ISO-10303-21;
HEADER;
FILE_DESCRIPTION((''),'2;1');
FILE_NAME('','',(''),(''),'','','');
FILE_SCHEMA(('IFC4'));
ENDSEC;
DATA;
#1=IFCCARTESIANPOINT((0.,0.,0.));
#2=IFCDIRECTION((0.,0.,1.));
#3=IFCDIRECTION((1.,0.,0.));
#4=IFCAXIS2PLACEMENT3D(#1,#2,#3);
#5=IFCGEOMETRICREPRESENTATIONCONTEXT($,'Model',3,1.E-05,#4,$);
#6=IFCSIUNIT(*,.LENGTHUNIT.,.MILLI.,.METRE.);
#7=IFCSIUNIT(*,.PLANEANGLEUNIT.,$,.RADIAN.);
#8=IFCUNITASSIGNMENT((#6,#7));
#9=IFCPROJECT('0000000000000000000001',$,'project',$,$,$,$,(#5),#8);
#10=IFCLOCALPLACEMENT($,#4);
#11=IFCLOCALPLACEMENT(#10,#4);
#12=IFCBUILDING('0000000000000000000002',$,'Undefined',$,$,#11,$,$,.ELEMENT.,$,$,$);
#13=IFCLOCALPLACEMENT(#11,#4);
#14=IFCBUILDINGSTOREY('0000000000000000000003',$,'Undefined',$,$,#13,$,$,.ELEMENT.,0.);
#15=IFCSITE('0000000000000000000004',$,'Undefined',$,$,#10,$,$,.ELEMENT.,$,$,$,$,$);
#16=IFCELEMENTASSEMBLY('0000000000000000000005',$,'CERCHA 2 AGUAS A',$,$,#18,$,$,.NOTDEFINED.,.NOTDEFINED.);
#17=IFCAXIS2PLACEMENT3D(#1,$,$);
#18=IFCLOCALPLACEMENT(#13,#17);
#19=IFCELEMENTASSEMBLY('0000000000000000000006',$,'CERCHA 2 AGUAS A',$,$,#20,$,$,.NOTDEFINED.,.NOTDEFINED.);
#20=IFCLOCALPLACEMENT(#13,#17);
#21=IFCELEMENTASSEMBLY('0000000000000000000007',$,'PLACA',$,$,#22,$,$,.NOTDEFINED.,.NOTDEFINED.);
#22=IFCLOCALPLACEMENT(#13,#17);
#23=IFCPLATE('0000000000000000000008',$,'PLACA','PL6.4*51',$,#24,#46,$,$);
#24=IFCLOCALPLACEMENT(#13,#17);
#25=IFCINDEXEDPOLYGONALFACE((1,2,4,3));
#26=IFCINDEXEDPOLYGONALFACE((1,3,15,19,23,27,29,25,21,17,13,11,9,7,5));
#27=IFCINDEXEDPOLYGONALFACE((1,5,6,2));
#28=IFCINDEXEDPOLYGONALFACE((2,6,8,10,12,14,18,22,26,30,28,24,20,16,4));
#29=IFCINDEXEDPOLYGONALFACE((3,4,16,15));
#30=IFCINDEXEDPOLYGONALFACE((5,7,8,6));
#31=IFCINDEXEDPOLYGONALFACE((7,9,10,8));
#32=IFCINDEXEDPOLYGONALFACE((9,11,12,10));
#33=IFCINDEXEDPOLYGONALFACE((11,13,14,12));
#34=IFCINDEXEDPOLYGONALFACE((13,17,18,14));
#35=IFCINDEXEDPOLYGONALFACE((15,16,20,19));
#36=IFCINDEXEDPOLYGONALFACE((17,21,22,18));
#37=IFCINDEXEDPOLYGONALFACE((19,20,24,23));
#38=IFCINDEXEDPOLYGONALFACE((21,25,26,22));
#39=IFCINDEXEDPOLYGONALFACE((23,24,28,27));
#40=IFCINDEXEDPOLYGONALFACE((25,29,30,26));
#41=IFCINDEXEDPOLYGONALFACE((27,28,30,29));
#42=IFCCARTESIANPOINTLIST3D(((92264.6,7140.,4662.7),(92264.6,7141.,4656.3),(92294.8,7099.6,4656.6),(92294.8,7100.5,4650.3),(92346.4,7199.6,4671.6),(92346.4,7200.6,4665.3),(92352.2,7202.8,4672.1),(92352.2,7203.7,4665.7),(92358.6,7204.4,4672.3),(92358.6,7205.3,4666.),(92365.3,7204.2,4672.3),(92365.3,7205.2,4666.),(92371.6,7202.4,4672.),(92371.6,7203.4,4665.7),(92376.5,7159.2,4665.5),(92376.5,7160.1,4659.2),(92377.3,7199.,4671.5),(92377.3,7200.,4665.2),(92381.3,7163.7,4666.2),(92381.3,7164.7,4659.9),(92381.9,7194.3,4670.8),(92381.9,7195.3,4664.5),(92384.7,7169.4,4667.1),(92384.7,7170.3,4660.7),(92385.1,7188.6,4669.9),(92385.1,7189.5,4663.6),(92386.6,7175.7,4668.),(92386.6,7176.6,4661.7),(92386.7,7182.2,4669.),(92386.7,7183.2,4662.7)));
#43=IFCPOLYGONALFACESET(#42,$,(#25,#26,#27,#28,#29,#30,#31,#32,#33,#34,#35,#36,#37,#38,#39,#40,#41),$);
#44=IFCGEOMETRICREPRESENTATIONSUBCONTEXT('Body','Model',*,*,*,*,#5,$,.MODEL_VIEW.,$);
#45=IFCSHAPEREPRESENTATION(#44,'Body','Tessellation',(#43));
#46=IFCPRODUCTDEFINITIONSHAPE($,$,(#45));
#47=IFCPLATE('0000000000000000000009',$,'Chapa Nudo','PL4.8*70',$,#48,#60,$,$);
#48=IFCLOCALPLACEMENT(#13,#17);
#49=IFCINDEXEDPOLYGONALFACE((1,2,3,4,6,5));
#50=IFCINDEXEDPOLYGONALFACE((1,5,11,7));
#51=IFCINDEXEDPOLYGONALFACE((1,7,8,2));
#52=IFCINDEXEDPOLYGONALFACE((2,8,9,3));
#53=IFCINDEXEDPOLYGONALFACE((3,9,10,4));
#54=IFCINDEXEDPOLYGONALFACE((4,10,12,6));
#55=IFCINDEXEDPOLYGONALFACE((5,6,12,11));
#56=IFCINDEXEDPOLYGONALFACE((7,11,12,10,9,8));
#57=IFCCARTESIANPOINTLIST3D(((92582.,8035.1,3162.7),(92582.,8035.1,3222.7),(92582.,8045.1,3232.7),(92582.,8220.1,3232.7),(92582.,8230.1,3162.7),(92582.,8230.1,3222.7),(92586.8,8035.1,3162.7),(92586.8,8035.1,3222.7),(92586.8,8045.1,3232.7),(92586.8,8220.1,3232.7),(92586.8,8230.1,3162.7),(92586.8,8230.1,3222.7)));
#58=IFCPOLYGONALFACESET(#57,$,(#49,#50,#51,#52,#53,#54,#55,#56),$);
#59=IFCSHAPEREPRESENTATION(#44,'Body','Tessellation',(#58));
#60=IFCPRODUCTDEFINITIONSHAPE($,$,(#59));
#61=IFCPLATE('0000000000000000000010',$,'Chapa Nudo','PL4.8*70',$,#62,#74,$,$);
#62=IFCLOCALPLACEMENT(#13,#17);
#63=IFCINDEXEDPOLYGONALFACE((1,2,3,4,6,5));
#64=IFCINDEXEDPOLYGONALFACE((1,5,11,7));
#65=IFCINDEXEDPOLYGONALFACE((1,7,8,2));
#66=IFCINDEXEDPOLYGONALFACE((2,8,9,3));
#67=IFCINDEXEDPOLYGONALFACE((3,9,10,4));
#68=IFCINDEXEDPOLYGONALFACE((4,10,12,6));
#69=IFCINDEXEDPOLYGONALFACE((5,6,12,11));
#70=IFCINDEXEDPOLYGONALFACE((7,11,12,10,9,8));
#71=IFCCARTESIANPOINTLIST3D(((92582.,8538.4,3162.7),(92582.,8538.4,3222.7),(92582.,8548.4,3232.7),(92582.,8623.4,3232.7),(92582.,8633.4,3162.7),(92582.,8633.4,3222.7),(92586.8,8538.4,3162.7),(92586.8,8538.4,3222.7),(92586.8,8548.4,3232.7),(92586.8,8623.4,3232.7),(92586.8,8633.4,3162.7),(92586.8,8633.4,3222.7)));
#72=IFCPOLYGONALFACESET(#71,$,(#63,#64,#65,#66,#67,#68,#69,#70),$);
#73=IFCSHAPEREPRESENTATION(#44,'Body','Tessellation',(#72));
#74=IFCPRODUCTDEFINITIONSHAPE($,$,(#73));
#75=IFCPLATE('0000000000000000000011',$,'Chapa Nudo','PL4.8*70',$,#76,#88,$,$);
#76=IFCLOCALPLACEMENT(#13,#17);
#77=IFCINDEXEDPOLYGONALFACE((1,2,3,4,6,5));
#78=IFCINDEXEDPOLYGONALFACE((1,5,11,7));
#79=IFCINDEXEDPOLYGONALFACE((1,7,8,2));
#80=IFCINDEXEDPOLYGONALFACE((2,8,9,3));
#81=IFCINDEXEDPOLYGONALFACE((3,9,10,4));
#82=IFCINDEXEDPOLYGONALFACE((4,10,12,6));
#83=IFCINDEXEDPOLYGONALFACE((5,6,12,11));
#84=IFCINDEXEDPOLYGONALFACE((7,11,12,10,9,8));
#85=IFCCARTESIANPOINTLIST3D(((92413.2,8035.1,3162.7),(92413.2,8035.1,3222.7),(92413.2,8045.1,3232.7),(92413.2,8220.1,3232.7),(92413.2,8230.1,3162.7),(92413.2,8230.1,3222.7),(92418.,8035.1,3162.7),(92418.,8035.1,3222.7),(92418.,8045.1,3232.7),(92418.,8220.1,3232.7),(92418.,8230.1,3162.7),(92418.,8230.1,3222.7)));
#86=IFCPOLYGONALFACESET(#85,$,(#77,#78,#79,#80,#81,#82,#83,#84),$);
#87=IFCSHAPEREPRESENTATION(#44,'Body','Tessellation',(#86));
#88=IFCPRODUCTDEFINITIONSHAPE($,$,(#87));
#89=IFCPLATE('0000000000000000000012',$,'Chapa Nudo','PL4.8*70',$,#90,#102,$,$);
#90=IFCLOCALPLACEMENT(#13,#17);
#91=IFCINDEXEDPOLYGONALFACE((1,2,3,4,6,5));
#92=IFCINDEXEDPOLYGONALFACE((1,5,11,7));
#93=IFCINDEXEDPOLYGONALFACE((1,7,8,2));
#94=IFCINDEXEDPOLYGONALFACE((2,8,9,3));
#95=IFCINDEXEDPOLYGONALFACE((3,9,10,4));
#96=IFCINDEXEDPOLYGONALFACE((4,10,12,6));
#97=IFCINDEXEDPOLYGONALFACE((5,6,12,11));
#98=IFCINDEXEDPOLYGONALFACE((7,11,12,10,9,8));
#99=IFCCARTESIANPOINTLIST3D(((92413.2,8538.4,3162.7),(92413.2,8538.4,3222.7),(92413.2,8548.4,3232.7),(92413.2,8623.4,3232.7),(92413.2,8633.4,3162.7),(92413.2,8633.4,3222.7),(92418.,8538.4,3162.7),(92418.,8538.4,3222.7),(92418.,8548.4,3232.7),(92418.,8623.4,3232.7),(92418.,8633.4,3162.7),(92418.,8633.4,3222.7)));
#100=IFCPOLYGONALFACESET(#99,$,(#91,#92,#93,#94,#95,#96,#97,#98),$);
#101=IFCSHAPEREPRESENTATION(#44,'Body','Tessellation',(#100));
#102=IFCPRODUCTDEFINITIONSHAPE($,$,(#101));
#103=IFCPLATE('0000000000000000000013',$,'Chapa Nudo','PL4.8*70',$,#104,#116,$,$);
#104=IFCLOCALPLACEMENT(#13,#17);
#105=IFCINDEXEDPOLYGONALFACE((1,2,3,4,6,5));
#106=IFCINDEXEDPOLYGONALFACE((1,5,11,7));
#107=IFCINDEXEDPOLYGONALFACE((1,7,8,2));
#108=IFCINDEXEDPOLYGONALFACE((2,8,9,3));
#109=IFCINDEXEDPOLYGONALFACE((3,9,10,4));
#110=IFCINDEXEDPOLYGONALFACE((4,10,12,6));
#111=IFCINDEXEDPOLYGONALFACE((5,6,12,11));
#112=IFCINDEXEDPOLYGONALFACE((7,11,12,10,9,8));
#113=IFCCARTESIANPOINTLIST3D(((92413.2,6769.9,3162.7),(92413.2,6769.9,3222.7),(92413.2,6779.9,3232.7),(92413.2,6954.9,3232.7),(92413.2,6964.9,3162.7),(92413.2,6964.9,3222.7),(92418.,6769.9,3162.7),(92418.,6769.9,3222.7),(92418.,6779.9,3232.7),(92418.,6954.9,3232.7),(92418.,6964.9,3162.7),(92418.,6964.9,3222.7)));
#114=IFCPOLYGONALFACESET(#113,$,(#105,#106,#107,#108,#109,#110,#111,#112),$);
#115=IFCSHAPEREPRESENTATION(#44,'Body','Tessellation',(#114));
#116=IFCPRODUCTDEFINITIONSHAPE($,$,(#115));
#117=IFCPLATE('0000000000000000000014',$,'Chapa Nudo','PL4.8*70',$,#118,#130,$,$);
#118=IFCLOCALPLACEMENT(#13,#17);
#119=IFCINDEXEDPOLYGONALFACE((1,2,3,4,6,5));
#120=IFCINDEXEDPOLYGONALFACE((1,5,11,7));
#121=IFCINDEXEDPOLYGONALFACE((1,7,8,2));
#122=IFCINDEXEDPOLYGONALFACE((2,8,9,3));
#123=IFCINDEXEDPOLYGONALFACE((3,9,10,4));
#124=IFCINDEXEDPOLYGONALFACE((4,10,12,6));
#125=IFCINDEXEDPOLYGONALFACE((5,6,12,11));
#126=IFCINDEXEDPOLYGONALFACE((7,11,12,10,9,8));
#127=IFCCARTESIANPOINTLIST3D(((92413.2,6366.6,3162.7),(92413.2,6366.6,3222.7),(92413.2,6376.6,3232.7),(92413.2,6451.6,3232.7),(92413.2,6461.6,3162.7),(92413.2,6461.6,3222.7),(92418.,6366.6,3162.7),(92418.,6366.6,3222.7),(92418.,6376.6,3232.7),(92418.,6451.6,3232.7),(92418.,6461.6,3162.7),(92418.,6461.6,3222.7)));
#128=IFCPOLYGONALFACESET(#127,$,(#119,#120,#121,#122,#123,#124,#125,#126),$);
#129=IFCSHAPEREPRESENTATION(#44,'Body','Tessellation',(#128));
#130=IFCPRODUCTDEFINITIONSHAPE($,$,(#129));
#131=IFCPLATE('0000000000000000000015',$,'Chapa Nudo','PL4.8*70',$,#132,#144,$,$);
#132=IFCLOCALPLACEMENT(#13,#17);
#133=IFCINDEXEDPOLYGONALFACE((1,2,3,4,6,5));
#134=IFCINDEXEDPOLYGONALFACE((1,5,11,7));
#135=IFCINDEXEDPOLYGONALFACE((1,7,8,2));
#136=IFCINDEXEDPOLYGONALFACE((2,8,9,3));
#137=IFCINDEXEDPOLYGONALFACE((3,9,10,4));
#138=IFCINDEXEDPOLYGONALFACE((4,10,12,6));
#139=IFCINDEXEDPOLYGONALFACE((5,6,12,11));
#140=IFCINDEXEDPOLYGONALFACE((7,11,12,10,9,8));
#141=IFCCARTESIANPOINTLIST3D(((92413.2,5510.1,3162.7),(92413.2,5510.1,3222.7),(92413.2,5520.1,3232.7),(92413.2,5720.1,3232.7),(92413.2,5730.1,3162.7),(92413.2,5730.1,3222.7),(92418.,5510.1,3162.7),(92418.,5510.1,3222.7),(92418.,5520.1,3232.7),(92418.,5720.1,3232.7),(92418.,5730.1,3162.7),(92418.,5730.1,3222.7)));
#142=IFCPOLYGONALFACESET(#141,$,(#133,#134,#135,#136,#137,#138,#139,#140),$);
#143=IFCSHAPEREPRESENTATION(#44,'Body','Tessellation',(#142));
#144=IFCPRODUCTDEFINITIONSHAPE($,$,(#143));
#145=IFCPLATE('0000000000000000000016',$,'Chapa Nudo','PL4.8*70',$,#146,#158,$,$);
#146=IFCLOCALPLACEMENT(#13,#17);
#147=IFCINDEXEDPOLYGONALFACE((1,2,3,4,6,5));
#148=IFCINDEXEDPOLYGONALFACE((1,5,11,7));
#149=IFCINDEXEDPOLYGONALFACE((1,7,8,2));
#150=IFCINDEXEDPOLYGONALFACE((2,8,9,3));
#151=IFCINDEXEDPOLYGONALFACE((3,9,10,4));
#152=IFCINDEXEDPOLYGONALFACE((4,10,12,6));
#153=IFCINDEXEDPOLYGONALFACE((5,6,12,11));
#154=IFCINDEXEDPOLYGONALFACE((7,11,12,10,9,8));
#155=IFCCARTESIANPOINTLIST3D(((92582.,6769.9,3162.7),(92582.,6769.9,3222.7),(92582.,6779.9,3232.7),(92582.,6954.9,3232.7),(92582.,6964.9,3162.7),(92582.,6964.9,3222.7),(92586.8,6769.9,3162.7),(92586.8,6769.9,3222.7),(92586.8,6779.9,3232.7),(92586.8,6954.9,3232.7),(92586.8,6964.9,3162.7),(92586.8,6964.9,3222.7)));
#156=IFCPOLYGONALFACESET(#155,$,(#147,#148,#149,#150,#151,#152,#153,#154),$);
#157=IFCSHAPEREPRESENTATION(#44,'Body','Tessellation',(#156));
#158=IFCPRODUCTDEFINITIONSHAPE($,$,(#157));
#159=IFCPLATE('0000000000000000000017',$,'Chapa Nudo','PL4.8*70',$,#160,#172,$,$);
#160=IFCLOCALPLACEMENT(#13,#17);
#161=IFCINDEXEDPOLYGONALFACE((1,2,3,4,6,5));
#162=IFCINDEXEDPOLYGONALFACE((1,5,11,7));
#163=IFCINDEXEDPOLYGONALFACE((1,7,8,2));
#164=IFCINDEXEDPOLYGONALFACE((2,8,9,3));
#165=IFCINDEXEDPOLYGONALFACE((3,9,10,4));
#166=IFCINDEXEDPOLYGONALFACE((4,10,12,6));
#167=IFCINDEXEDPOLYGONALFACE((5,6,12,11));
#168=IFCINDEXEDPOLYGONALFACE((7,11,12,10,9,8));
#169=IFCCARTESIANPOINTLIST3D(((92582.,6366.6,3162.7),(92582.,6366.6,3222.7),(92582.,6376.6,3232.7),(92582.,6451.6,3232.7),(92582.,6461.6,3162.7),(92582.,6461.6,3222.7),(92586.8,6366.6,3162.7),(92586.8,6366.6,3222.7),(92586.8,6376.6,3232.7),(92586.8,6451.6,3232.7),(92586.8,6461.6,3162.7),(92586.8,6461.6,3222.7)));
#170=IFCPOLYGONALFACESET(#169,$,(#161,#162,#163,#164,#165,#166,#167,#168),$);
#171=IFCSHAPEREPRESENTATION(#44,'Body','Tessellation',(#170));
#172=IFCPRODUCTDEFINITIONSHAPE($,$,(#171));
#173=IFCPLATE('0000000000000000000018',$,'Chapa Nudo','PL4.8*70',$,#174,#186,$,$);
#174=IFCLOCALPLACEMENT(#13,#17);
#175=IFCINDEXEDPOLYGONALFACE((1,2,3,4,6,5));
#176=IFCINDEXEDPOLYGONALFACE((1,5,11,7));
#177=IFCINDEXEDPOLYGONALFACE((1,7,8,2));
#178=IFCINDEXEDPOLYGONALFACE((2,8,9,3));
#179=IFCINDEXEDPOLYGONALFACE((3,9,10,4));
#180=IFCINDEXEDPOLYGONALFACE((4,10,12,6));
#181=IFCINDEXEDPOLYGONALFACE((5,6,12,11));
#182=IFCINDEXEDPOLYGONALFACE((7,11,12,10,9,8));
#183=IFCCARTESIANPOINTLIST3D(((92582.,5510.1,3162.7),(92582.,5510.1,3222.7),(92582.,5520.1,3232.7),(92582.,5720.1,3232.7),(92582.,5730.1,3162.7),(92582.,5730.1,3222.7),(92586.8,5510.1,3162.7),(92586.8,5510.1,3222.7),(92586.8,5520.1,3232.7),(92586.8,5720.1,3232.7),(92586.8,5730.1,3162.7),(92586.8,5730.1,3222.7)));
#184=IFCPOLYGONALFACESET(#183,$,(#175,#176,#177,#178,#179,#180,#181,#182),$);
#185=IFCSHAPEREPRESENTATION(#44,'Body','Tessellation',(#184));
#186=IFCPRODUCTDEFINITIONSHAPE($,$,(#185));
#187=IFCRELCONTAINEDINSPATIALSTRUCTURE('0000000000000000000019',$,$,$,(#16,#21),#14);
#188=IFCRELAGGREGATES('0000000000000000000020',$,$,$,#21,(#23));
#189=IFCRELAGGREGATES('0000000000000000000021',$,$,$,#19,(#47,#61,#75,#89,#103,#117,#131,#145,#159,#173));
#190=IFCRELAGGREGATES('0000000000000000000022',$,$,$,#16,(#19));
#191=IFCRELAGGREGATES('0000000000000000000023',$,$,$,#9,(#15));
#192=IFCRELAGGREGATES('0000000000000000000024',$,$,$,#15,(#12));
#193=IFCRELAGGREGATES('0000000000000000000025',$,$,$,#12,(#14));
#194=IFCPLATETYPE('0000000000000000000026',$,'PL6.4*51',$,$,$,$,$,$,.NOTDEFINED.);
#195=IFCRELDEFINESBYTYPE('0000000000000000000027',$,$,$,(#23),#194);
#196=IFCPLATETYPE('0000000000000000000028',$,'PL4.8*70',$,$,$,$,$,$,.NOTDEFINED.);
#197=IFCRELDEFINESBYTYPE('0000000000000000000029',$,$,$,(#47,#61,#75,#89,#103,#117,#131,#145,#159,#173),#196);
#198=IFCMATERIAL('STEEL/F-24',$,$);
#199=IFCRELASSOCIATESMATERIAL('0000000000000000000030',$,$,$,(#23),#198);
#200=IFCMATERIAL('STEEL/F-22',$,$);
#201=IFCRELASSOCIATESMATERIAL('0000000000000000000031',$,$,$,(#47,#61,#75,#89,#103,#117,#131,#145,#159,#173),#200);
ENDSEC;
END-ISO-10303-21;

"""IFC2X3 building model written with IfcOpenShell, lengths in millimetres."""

from ifc_helpers import new_model, si_unit, frame, frame_2d, origin_with_axes, place, context, subcontext, project, spatial, polyline, circle_curve, parameter, trimmed, segment, composite_curve, outline, extrude, material, type_object, element, aggregate, save


model = new_model("IFC2X3")

# Units and contexts
model_context = context("Model", 3, precision=1e-05, world=origin_with_axes())
body_context = subcontext(model_context, "Body", "Model", "MODEL_VIEW")
ifc_project = project(units=[si_unit("LENGTHUNIT", "METRE", prefix="MILLI"), si_unit("PLANEANGLEUNIT", "RADIAN")], contexts=[model_context])

# Site, building, storey
site_placement = place(None, origin_with_axes())
site = spatial("IfcSite", under=ifc_project, at=site_placement, Name="Undefined", CompositionType="ELEMENT")
building_placement = place(site_placement, origin_with_axes())
building = spatial("IfcBuilding", under=site, at=building_placement, Name="Undefined", CompositionType="ELEMENT")
storey_placement = place(building_placement, origin_with_axes())
storey = spatial("IfcBuildingStorey", under=building, at=storey_placement, Name="Undefined", CompositionType="ELEMENT", Elevation=0.0)

# Shared definitions
ifc_material_1 = material(Name="STEEL/F-22")

# Element assemblies
assembly_1_placement = place(storey_placement, origin_with_axes())
assembly_1 = element("IfcElementAssembly", 1, at=assembly_1_placement, inside=storey, Name="CERCHA 2 AGUAS A", AssemblyPlace="NOTDEFINED", PredefinedType="NOTDEFINED")
assembly_2_placement = place(assembly_1_placement, origin_with_axes())
assembly_2 = element("IfcElementAssembly", 2, at=assembly_2_placement, Name="CERCHA 2 AGUAS A", AssemblyPlace="NOTDEFINED", PredefinedType="NOTDEFINED")

# Element assembly, plate
assembly_3_placement = place(storey_placement, origin_with_axes())
assembly_3 = element("IfcElementAssembly", 3, at=assembly_3_placement, inside=storey, Name="PLACA", AssemblyPlace="NOTDEFINED", PredefinedType="NOTDEFINED")
ifc_material_2 = material(Name="STEEL/F-24")
plate_type_1 = type_object("IfcPlateType", Name="PL6.4*51", PredefinedType="NOTDEFINED")
plate_1_placement = place(assembly_3_placement, frame((92397.0, 7174.6, 4664.6), z_axis=(0.00003, -0.148316, 0.98894), x_axis=(-0.593392, 0.796009, 0.119399)))
plate_1 = element("IfcPlate", 4, at=plate_1_placement, type_object=plate_type_1, material=ifc_material_2, Name="PLACA", Description="PL6.4*51", context=body_context, shape_type="SweptSolid", body=[
    extrude(outline(composite_curve([segment(trimmed(circle_curve(frame_2d((25.4, 25.4), x_axis=(-1.0, 0.0)), 25.4), [parameter(0.0)], [parameter(1.570796)], True, "PARAMETER"), True, "CONTINUOUS"), segment(polyline([(25.4, 0.0), (25.4, 0.0)]), True, "CONTINUOUS"), segment(trimmed(circle_curve(frame_2d((25.4, 25.4), x_axis=(0.0, -1.0)), 25.4), [parameter(0.0)], [parameter(1.570797)], True, "PARAMETER"), True, "CONTINUOUS"), segment(polyline([(50.8, 25.4), (50.8, 127.0), (0.0, 127.0), (0.0, 25.4)]), True, "CONTINUOUS")], self_intersect=True)), frame((0.0, 0.0, -3.2), z_axis=(0.0, 0.0, 1.0), x_axis=(1.0, 0.0, 0.0)), (0.0, 0.0, 1.0), 6.4),
])
aggregate(assembly_3, [plate_1])

# Plates
plate_type_2 = type_object("IfcPlateType", Name="PL4.8*70", PredefinedType="NOTDEFINED")
plate_2_placement = place(assembly_2_placement, frame((92584.4, 8230.1, 3232.7), z_axis=(-1.0, 0.0, 0.0), x_axis=(0.0, 0.0, -1.0)))
plate_2 = element("IfcPlate", 5, at=plate_2_placement, type_object=plate_type_2, material=ifc_material_1, Name="Chapa Nudo", Description="PL4.8*70", context=body_context, shape_type="SweptSolid", body=[
    extrude(outline(polyline([(0.0, 10.0), (10.0, 0.0), (70.0, 0.0), (70.0, 195.0), (10.0, 195.0), (0.0, 185.0), (0.0, 10.0)])), frame((0.0, 0.0, -2.4), z_axis=(0.0, 0.0, 1.0), x_axis=(1.0, 0.0, 0.0)), (0.0, 0.0, 1.0), 4.8),
])
plate_3_placement = place(assembly_2_placement, frame((92584.4, 8633.4, 3232.7), z_axis=(-1.0, 0.0, 0.0), x_axis=(0.0, 0.0, -1.0)))
plate_3 = element("IfcPlate", 6, at=plate_3_placement, type_object=plate_type_2, material=ifc_material_1, Name="Chapa Nudo", Description="PL4.8*70", context=body_context, shape_type="SweptSolid", body=[
    extrude(outline(polyline([(0.0, 10.0), (10.0, 0.0), (70.0, 0.0), (70.0, 95.0), (10.0, 95.0), (0.0, 85.0), (0.0, 10.0)])), frame((0.0, 0.0, -2.4), z_axis=(0.0, 0.0, 1.0), x_axis=(1.0, 0.0, 0.0)), (0.0, 0.0, 1.0), 4.8),
])
plate_4_placement = place(assembly_2_placement, frame((92415.6, 8230.1, 3232.7), z_axis=(-1.0, 0.0, 0.0), x_axis=(0.0, 0.0, -1.0)))
plate_4 = element("IfcPlate", 7, at=plate_4_placement, type_object=plate_type_2, material=ifc_material_1, Name="Chapa Nudo", Description="PL4.8*70", context=body_context, shape_type="SweptSolid", body=[
    extrude(outline(polyline([(0.0, 10.0), (10.0, 0.0), (70.0, 0.0), (70.0, 195.0), (10.0, 195.0), (0.0, 185.0), (0.0, 10.0)])), frame((0.0, 0.0, -2.4), z_axis=(0.0, 0.0, 1.0), x_axis=(1.0, 0.0, 0.0)), (0.0, 0.0, 1.0), 4.8),
])
plate_5_placement = place(assembly_2_placement, frame((92415.6, 8633.4, 3232.7), z_axis=(-1.0, 0.0, 0.0), x_axis=(0.0, 0.0, -1.0)))
plate_5 = element("IfcPlate", 8, at=plate_5_placement, type_object=plate_type_2, material=ifc_material_1, Name="Chapa Nudo", Description="PL4.8*70", context=body_context, shape_type="SweptSolid", body=[
    extrude(outline(polyline([(0.0, 10.0), (10.0, 0.0), (70.0, 0.0), (70.0, 95.0), (10.0, 95.0), (0.0, 85.0), (0.0, 10.0)])), frame((0.0, 0.0, -2.4), z_axis=(0.0, 0.0, 1.0), x_axis=(1.0, 0.0, 0.0)), (0.0, 0.0, 1.0), 4.8),
])
plate_6_placement = place(assembly_2_placement, frame((92415.6, 6769.9, 3232.7), z_axis=(1.0, 0.0, 0.0), x_axis=(0.0, 0.0, -1.0)))
plate_6 = element("IfcPlate", 9, at=plate_6_placement, type_object=plate_type_2, material=ifc_material_1, Name="Chapa Nudo", Description="PL4.8*70", context=body_context, shape_type="SweptSolid", body=[
    extrude(outline(polyline([(0.0, 10.0), (10.0, 0.0), (70.0, 0.0), (70.0, 195.0), (10.0, 195.0), (0.0, 185.0), (0.0, 10.0)])), frame((0.0, 0.0, -2.4), z_axis=(0.0, 0.0, 1.0), x_axis=(1.0, 0.0, 0.0)), (0.0, 0.0, 1.0), 4.8),
])
plate_7_placement = place(assembly_2_placement, frame((92415.6, 6366.6, 3232.7), z_axis=(1.0, 0.0, 0.0), x_axis=(0.0, 0.0, -1.0)))
plate_7 = element("IfcPlate", 10, at=plate_7_placement, type_object=plate_type_2, material=ifc_material_1, Name="Chapa Nudo", Description="PL4.8*70", context=body_context, shape_type="SweptSolid", body=[
    extrude(outline(polyline([(0.0, 10.0), (10.0, 0.0), (70.0, 0.0), (70.0, 95.0), (10.0, 95.0), (0.0, 85.0), (0.0, 10.0)])), frame((0.0, 0.0, -2.4), z_axis=(0.0, 0.0, 1.0), x_axis=(1.0, 0.0, 0.0)), (0.0, 0.0, 1.0), 4.8),
])
plate_8_placement = place(assembly_2_placement, frame((92415.6, 5510.1, 3232.7), z_axis=(1.0, 0.0, 0.0), x_axis=(0.0, 0.0, -1.0)))
plate_8 = element("IfcPlate", 11, at=plate_8_placement, type_object=plate_type_2, material=ifc_material_1, Name="Chapa Nudo", Description="PL4.8*70", context=body_context, shape_type="SweptSolid", body=[
    extrude(outline(polyline([(0.0, 10.0), (10.0, 0.0), (70.0, 0.0), (70.0, 220.0), (10.0, 220.0), (0.0, 210.0), (0.0, 10.0)])), frame((0.0, 0.0, -2.4), z_axis=(0.0, 0.0, 1.0), x_axis=(1.0, 0.0, 0.0)), (0.0, 0.0, 1.0), 4.8),
])
plate_9_placement = place(assembly_2_placement, frame((92584.4, 6769.9, 3232.7), z_axis=(1.0, 0.0, 0.0), x_axis=(0.0, 0.0, -1.0)))
plate_9 = element("IfcPlate", 12, at=plate_9_placement, type_object=plate_type_2, material=ifc_material_1, Name="Chapa Nudo", Description="PL4.8*70", context=body_context, shape_type="SweptSolid", body=[
    extrude(outline(polyline([(0.0, 10.0), (10.0, 0.0), (70.0, 0.0), (70.0, 195.0), (10.0, 195.0), (0.0, 185.0), (0.0, 10.0)])), frame((0.0, 0.0, -2.4), z_axis=(0.0, 0.0, 1.0), x_axis=(1.0, 0.0, 0.0)), (0.0, 0.0, 1.0), 4.8),
])
plate_10_placement = place(assembly_2_placement, frame((92584.4, 6366.6, 3232.7), z_axis=(1.0, 0.0, 0.0), x_axis=(0.0, 0.0, -1.0)))
plate_10 = element("IfcPlate", 13, at=plate_10_placement, type_object=plate_type_2, material=ifc_material_1, Name="Chapa Nudo", Description="PL4.8*70", context=body_context, shape_type="SweptSolid", body=[
    extrude(outline(polyline([(0.0, 10.0), (10.0, 0.0), (70.0, 0.0), (70.0, 95.0), (10.0, 95.0), (0.0, 85.0), (0.0, 10.0)])), frame((0.0, 0.0, -2.4), z_axis=(0.0, 0.0, 1.0), x_axis=(1.0, 0.0, 0.0)), (0.0, 0.0, 1.0), 4.8),
])
plate_11_placement = place(assembly_2_placement, frame((92584.4, 5510.1, 3232.7), z_axis=(1.0, 0.0, 0.0), x_axis=(0.0, 0.0, -1.0)))
plate_11 = element("IfcPlate", 14, at=plate_11_placement, type_object=plate_type_2, material=ifc_material_1, Name="Chapa Nudo", Description="PL4.8*70", context=body_context, shape_type="SweptSolid", body=[
    extrude(outline(polyline([(0.0, 10.0), (10.0, 0.0), (70.0, 0.0), (70.0, 220.0), (10.0, 220.0), (0.0, 210.0), (0.0, 10.0)])), frame((0.0, 0.0, -2.4), z_axis=(0.0, 0.0, 1.0), x_axis=(1.0, 0.0, 0.0)), (0.0, 0.0, 1.0), 4.8),
])

aggregate(assembly_2, [plate_2, plate_3, plate_4, plate_5, plate_6, plate_7, plate_8, plate_9, plate_10, plate_11])
aggregate(assembly_1, [assembly_2])

save(model, "model.ifc")
